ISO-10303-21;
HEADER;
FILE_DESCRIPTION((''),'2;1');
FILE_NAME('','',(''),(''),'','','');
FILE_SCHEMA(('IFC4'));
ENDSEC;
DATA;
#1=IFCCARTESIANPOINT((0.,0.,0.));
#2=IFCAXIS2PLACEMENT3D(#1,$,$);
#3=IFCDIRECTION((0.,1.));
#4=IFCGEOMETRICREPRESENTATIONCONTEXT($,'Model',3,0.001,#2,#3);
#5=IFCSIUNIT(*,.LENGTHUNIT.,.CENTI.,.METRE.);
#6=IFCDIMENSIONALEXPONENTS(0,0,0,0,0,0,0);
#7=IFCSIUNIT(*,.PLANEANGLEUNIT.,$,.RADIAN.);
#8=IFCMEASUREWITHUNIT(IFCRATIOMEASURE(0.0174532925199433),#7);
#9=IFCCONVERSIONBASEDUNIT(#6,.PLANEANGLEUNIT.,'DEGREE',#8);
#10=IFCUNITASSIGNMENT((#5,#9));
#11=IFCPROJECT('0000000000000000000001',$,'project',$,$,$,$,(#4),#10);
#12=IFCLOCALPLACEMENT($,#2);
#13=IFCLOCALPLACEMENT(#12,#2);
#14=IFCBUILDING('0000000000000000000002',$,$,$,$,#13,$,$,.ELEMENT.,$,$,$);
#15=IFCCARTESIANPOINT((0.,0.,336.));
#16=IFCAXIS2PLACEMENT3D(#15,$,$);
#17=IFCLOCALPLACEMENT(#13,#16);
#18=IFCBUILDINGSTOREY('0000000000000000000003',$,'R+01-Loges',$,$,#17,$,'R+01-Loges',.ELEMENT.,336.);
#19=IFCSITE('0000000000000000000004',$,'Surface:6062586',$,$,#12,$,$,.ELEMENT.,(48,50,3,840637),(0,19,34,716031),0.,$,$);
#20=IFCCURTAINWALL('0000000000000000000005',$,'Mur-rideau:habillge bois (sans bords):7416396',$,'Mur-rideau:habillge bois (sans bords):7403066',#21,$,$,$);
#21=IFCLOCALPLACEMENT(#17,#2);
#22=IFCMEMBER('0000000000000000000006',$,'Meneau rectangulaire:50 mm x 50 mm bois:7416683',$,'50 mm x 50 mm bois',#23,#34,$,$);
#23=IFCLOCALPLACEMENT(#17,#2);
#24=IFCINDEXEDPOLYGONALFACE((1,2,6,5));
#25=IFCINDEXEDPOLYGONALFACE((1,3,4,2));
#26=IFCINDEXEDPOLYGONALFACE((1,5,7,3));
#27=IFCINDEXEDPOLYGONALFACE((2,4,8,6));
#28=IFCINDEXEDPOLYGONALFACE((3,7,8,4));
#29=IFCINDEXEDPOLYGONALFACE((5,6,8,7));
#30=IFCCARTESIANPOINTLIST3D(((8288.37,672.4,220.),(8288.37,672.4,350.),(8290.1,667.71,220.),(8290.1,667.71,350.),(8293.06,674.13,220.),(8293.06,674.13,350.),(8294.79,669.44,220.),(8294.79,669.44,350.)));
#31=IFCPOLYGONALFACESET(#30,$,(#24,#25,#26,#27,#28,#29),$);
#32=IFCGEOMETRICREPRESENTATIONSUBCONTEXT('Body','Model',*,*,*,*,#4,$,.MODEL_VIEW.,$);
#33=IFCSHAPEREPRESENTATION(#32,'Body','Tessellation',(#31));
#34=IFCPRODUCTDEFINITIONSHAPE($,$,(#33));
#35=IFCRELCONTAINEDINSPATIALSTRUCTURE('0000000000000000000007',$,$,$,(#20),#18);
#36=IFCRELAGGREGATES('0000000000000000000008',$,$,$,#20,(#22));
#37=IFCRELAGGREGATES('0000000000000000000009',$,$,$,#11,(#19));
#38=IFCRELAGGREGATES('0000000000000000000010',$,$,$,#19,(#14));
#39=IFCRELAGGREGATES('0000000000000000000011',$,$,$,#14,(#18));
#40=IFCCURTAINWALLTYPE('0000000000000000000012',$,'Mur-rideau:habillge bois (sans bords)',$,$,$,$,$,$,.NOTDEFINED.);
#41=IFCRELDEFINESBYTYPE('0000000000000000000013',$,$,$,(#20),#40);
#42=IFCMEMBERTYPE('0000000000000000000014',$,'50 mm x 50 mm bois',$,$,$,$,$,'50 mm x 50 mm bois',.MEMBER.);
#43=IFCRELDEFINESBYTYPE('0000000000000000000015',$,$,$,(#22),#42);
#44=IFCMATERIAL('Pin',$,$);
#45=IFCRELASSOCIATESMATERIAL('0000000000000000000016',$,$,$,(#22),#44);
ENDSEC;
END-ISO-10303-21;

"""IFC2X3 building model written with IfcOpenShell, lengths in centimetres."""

from ifc_helpers import new_model, entity, si_unit, converted_unit, direction, frame, origin, origin_2d_with_axis, place, context, subcontext, project, spatial, rectangle, extrude, source, transform, mapped, material, type_object, type_shapes, element, aggregate, save


model = new_model("IFC2X3")

# Units and contexts
model_context = context("Model", 3, precision=0.001, world=origin(), true_north=direction((0.0, 1.0)))
body_context = subcontext(model_context, "Body", "Model", "MODEL_VIEW")
ifc_project = project(units=[si_unit("LENGTHUNIT", "METRE", prefix="CENTI"), converted_unit("PLANEANGLEUNIT", "DEGREE", entity("IfcRatioMeasure", 0.0174532925199433), si_unit("PLANEANGLEUNIT", "RADIAN"), dimensions=[0, 0, 0, 0, 0, 0, 0])], contexts=[model_context])

# Site, building, storey
site_placement = place(None, origin())
site = spatial("IfcSite", under=ifc_project, at=site_placement, Name="Surface:6062586", CompositionType="ELEMENT", RefLatitude=(48, 50, 3, 840637), RefLongitude=(0, 19, 34, 716031), RefElevation=0.0)
building_placement = place(site_placement, origin())
building = spatial("IfcBuilding", under=site, at=building_placement, CompositionType="ELEMENT")
storey_placement = place(building_placement, frame((0.0, 0.0, 336.0)))
storey = spatial("IfcBuildingStorey", under=building, at=storey_placement, Name="R+01-Loges", LongName="R+01-Loges", CompositionType="ELEMENT", Elevation=336.0)

# Curtain wall, member
curtain_wall_type_1 = type_object("IfcCurtainWallType", Name="Mur-rideau:habillge bois (sans bords)", PredefinedType="NOTDEFINED")
curtain_wall_1_placement = place(storey_placement, frame((0.0, 0.0, -336.0)))
curtain_wall_1 = element("IfcCurtainWall", 1, at=curtain_wall_1_placement, inside=storey, type_object=curtain_wall_type_1, Name="Mur-rideau:habillge bois (sans bords):7416396", ObjectType="Mur-rideau:habillge bois (sans bords):7403066")
ifc_material_1 = material(Name="Pin")
member_type = type_object("IfcMemberType", Name="50 mm x 50 mm bois", ElementType="50 mm x 50 mm bois", PredefinedType="MEMBER")
shared_shape_1 = source(origin(), body_context, "Body", "SweptSolid", [
    extrude(rectangle(XDim=5.0, YDim=5.0, at=origin_2d_with_axis()), frame((0.0, 0.0, -130.0), z_axis=(0.0, 0.0, 1.0), x_axis=(0.0, -1.0, 0.0)), (0.0, 0.0, 1.0), 130.0),
])
type_shapes(member_type, [shared_shape_1])
member_1_placement = place(storey_placement, frame((8291.58, 670.92, 220.0), z_axis=(0.0, 0.0, -1.0), x_axis=(0.938227, 0.34602, 0.0)))
member_1 = element("IfcMember", 2, at=member_1_placement, type_object=member_type, material=ifc_material_1, Name="Meneau rectangulaire:50 mm x 50 mm bois:7416683", ObjectType="50 mm x 50 mm bois", context=body_context, shape_type="MappedRepresentation", body=[
    mapped(shared_shape_1, transform((0.0, 0.0, 0.0), scale=1.0)),
])
aggregate(curtain_wall_1, [member_1])

save(model, "model.ifc")
